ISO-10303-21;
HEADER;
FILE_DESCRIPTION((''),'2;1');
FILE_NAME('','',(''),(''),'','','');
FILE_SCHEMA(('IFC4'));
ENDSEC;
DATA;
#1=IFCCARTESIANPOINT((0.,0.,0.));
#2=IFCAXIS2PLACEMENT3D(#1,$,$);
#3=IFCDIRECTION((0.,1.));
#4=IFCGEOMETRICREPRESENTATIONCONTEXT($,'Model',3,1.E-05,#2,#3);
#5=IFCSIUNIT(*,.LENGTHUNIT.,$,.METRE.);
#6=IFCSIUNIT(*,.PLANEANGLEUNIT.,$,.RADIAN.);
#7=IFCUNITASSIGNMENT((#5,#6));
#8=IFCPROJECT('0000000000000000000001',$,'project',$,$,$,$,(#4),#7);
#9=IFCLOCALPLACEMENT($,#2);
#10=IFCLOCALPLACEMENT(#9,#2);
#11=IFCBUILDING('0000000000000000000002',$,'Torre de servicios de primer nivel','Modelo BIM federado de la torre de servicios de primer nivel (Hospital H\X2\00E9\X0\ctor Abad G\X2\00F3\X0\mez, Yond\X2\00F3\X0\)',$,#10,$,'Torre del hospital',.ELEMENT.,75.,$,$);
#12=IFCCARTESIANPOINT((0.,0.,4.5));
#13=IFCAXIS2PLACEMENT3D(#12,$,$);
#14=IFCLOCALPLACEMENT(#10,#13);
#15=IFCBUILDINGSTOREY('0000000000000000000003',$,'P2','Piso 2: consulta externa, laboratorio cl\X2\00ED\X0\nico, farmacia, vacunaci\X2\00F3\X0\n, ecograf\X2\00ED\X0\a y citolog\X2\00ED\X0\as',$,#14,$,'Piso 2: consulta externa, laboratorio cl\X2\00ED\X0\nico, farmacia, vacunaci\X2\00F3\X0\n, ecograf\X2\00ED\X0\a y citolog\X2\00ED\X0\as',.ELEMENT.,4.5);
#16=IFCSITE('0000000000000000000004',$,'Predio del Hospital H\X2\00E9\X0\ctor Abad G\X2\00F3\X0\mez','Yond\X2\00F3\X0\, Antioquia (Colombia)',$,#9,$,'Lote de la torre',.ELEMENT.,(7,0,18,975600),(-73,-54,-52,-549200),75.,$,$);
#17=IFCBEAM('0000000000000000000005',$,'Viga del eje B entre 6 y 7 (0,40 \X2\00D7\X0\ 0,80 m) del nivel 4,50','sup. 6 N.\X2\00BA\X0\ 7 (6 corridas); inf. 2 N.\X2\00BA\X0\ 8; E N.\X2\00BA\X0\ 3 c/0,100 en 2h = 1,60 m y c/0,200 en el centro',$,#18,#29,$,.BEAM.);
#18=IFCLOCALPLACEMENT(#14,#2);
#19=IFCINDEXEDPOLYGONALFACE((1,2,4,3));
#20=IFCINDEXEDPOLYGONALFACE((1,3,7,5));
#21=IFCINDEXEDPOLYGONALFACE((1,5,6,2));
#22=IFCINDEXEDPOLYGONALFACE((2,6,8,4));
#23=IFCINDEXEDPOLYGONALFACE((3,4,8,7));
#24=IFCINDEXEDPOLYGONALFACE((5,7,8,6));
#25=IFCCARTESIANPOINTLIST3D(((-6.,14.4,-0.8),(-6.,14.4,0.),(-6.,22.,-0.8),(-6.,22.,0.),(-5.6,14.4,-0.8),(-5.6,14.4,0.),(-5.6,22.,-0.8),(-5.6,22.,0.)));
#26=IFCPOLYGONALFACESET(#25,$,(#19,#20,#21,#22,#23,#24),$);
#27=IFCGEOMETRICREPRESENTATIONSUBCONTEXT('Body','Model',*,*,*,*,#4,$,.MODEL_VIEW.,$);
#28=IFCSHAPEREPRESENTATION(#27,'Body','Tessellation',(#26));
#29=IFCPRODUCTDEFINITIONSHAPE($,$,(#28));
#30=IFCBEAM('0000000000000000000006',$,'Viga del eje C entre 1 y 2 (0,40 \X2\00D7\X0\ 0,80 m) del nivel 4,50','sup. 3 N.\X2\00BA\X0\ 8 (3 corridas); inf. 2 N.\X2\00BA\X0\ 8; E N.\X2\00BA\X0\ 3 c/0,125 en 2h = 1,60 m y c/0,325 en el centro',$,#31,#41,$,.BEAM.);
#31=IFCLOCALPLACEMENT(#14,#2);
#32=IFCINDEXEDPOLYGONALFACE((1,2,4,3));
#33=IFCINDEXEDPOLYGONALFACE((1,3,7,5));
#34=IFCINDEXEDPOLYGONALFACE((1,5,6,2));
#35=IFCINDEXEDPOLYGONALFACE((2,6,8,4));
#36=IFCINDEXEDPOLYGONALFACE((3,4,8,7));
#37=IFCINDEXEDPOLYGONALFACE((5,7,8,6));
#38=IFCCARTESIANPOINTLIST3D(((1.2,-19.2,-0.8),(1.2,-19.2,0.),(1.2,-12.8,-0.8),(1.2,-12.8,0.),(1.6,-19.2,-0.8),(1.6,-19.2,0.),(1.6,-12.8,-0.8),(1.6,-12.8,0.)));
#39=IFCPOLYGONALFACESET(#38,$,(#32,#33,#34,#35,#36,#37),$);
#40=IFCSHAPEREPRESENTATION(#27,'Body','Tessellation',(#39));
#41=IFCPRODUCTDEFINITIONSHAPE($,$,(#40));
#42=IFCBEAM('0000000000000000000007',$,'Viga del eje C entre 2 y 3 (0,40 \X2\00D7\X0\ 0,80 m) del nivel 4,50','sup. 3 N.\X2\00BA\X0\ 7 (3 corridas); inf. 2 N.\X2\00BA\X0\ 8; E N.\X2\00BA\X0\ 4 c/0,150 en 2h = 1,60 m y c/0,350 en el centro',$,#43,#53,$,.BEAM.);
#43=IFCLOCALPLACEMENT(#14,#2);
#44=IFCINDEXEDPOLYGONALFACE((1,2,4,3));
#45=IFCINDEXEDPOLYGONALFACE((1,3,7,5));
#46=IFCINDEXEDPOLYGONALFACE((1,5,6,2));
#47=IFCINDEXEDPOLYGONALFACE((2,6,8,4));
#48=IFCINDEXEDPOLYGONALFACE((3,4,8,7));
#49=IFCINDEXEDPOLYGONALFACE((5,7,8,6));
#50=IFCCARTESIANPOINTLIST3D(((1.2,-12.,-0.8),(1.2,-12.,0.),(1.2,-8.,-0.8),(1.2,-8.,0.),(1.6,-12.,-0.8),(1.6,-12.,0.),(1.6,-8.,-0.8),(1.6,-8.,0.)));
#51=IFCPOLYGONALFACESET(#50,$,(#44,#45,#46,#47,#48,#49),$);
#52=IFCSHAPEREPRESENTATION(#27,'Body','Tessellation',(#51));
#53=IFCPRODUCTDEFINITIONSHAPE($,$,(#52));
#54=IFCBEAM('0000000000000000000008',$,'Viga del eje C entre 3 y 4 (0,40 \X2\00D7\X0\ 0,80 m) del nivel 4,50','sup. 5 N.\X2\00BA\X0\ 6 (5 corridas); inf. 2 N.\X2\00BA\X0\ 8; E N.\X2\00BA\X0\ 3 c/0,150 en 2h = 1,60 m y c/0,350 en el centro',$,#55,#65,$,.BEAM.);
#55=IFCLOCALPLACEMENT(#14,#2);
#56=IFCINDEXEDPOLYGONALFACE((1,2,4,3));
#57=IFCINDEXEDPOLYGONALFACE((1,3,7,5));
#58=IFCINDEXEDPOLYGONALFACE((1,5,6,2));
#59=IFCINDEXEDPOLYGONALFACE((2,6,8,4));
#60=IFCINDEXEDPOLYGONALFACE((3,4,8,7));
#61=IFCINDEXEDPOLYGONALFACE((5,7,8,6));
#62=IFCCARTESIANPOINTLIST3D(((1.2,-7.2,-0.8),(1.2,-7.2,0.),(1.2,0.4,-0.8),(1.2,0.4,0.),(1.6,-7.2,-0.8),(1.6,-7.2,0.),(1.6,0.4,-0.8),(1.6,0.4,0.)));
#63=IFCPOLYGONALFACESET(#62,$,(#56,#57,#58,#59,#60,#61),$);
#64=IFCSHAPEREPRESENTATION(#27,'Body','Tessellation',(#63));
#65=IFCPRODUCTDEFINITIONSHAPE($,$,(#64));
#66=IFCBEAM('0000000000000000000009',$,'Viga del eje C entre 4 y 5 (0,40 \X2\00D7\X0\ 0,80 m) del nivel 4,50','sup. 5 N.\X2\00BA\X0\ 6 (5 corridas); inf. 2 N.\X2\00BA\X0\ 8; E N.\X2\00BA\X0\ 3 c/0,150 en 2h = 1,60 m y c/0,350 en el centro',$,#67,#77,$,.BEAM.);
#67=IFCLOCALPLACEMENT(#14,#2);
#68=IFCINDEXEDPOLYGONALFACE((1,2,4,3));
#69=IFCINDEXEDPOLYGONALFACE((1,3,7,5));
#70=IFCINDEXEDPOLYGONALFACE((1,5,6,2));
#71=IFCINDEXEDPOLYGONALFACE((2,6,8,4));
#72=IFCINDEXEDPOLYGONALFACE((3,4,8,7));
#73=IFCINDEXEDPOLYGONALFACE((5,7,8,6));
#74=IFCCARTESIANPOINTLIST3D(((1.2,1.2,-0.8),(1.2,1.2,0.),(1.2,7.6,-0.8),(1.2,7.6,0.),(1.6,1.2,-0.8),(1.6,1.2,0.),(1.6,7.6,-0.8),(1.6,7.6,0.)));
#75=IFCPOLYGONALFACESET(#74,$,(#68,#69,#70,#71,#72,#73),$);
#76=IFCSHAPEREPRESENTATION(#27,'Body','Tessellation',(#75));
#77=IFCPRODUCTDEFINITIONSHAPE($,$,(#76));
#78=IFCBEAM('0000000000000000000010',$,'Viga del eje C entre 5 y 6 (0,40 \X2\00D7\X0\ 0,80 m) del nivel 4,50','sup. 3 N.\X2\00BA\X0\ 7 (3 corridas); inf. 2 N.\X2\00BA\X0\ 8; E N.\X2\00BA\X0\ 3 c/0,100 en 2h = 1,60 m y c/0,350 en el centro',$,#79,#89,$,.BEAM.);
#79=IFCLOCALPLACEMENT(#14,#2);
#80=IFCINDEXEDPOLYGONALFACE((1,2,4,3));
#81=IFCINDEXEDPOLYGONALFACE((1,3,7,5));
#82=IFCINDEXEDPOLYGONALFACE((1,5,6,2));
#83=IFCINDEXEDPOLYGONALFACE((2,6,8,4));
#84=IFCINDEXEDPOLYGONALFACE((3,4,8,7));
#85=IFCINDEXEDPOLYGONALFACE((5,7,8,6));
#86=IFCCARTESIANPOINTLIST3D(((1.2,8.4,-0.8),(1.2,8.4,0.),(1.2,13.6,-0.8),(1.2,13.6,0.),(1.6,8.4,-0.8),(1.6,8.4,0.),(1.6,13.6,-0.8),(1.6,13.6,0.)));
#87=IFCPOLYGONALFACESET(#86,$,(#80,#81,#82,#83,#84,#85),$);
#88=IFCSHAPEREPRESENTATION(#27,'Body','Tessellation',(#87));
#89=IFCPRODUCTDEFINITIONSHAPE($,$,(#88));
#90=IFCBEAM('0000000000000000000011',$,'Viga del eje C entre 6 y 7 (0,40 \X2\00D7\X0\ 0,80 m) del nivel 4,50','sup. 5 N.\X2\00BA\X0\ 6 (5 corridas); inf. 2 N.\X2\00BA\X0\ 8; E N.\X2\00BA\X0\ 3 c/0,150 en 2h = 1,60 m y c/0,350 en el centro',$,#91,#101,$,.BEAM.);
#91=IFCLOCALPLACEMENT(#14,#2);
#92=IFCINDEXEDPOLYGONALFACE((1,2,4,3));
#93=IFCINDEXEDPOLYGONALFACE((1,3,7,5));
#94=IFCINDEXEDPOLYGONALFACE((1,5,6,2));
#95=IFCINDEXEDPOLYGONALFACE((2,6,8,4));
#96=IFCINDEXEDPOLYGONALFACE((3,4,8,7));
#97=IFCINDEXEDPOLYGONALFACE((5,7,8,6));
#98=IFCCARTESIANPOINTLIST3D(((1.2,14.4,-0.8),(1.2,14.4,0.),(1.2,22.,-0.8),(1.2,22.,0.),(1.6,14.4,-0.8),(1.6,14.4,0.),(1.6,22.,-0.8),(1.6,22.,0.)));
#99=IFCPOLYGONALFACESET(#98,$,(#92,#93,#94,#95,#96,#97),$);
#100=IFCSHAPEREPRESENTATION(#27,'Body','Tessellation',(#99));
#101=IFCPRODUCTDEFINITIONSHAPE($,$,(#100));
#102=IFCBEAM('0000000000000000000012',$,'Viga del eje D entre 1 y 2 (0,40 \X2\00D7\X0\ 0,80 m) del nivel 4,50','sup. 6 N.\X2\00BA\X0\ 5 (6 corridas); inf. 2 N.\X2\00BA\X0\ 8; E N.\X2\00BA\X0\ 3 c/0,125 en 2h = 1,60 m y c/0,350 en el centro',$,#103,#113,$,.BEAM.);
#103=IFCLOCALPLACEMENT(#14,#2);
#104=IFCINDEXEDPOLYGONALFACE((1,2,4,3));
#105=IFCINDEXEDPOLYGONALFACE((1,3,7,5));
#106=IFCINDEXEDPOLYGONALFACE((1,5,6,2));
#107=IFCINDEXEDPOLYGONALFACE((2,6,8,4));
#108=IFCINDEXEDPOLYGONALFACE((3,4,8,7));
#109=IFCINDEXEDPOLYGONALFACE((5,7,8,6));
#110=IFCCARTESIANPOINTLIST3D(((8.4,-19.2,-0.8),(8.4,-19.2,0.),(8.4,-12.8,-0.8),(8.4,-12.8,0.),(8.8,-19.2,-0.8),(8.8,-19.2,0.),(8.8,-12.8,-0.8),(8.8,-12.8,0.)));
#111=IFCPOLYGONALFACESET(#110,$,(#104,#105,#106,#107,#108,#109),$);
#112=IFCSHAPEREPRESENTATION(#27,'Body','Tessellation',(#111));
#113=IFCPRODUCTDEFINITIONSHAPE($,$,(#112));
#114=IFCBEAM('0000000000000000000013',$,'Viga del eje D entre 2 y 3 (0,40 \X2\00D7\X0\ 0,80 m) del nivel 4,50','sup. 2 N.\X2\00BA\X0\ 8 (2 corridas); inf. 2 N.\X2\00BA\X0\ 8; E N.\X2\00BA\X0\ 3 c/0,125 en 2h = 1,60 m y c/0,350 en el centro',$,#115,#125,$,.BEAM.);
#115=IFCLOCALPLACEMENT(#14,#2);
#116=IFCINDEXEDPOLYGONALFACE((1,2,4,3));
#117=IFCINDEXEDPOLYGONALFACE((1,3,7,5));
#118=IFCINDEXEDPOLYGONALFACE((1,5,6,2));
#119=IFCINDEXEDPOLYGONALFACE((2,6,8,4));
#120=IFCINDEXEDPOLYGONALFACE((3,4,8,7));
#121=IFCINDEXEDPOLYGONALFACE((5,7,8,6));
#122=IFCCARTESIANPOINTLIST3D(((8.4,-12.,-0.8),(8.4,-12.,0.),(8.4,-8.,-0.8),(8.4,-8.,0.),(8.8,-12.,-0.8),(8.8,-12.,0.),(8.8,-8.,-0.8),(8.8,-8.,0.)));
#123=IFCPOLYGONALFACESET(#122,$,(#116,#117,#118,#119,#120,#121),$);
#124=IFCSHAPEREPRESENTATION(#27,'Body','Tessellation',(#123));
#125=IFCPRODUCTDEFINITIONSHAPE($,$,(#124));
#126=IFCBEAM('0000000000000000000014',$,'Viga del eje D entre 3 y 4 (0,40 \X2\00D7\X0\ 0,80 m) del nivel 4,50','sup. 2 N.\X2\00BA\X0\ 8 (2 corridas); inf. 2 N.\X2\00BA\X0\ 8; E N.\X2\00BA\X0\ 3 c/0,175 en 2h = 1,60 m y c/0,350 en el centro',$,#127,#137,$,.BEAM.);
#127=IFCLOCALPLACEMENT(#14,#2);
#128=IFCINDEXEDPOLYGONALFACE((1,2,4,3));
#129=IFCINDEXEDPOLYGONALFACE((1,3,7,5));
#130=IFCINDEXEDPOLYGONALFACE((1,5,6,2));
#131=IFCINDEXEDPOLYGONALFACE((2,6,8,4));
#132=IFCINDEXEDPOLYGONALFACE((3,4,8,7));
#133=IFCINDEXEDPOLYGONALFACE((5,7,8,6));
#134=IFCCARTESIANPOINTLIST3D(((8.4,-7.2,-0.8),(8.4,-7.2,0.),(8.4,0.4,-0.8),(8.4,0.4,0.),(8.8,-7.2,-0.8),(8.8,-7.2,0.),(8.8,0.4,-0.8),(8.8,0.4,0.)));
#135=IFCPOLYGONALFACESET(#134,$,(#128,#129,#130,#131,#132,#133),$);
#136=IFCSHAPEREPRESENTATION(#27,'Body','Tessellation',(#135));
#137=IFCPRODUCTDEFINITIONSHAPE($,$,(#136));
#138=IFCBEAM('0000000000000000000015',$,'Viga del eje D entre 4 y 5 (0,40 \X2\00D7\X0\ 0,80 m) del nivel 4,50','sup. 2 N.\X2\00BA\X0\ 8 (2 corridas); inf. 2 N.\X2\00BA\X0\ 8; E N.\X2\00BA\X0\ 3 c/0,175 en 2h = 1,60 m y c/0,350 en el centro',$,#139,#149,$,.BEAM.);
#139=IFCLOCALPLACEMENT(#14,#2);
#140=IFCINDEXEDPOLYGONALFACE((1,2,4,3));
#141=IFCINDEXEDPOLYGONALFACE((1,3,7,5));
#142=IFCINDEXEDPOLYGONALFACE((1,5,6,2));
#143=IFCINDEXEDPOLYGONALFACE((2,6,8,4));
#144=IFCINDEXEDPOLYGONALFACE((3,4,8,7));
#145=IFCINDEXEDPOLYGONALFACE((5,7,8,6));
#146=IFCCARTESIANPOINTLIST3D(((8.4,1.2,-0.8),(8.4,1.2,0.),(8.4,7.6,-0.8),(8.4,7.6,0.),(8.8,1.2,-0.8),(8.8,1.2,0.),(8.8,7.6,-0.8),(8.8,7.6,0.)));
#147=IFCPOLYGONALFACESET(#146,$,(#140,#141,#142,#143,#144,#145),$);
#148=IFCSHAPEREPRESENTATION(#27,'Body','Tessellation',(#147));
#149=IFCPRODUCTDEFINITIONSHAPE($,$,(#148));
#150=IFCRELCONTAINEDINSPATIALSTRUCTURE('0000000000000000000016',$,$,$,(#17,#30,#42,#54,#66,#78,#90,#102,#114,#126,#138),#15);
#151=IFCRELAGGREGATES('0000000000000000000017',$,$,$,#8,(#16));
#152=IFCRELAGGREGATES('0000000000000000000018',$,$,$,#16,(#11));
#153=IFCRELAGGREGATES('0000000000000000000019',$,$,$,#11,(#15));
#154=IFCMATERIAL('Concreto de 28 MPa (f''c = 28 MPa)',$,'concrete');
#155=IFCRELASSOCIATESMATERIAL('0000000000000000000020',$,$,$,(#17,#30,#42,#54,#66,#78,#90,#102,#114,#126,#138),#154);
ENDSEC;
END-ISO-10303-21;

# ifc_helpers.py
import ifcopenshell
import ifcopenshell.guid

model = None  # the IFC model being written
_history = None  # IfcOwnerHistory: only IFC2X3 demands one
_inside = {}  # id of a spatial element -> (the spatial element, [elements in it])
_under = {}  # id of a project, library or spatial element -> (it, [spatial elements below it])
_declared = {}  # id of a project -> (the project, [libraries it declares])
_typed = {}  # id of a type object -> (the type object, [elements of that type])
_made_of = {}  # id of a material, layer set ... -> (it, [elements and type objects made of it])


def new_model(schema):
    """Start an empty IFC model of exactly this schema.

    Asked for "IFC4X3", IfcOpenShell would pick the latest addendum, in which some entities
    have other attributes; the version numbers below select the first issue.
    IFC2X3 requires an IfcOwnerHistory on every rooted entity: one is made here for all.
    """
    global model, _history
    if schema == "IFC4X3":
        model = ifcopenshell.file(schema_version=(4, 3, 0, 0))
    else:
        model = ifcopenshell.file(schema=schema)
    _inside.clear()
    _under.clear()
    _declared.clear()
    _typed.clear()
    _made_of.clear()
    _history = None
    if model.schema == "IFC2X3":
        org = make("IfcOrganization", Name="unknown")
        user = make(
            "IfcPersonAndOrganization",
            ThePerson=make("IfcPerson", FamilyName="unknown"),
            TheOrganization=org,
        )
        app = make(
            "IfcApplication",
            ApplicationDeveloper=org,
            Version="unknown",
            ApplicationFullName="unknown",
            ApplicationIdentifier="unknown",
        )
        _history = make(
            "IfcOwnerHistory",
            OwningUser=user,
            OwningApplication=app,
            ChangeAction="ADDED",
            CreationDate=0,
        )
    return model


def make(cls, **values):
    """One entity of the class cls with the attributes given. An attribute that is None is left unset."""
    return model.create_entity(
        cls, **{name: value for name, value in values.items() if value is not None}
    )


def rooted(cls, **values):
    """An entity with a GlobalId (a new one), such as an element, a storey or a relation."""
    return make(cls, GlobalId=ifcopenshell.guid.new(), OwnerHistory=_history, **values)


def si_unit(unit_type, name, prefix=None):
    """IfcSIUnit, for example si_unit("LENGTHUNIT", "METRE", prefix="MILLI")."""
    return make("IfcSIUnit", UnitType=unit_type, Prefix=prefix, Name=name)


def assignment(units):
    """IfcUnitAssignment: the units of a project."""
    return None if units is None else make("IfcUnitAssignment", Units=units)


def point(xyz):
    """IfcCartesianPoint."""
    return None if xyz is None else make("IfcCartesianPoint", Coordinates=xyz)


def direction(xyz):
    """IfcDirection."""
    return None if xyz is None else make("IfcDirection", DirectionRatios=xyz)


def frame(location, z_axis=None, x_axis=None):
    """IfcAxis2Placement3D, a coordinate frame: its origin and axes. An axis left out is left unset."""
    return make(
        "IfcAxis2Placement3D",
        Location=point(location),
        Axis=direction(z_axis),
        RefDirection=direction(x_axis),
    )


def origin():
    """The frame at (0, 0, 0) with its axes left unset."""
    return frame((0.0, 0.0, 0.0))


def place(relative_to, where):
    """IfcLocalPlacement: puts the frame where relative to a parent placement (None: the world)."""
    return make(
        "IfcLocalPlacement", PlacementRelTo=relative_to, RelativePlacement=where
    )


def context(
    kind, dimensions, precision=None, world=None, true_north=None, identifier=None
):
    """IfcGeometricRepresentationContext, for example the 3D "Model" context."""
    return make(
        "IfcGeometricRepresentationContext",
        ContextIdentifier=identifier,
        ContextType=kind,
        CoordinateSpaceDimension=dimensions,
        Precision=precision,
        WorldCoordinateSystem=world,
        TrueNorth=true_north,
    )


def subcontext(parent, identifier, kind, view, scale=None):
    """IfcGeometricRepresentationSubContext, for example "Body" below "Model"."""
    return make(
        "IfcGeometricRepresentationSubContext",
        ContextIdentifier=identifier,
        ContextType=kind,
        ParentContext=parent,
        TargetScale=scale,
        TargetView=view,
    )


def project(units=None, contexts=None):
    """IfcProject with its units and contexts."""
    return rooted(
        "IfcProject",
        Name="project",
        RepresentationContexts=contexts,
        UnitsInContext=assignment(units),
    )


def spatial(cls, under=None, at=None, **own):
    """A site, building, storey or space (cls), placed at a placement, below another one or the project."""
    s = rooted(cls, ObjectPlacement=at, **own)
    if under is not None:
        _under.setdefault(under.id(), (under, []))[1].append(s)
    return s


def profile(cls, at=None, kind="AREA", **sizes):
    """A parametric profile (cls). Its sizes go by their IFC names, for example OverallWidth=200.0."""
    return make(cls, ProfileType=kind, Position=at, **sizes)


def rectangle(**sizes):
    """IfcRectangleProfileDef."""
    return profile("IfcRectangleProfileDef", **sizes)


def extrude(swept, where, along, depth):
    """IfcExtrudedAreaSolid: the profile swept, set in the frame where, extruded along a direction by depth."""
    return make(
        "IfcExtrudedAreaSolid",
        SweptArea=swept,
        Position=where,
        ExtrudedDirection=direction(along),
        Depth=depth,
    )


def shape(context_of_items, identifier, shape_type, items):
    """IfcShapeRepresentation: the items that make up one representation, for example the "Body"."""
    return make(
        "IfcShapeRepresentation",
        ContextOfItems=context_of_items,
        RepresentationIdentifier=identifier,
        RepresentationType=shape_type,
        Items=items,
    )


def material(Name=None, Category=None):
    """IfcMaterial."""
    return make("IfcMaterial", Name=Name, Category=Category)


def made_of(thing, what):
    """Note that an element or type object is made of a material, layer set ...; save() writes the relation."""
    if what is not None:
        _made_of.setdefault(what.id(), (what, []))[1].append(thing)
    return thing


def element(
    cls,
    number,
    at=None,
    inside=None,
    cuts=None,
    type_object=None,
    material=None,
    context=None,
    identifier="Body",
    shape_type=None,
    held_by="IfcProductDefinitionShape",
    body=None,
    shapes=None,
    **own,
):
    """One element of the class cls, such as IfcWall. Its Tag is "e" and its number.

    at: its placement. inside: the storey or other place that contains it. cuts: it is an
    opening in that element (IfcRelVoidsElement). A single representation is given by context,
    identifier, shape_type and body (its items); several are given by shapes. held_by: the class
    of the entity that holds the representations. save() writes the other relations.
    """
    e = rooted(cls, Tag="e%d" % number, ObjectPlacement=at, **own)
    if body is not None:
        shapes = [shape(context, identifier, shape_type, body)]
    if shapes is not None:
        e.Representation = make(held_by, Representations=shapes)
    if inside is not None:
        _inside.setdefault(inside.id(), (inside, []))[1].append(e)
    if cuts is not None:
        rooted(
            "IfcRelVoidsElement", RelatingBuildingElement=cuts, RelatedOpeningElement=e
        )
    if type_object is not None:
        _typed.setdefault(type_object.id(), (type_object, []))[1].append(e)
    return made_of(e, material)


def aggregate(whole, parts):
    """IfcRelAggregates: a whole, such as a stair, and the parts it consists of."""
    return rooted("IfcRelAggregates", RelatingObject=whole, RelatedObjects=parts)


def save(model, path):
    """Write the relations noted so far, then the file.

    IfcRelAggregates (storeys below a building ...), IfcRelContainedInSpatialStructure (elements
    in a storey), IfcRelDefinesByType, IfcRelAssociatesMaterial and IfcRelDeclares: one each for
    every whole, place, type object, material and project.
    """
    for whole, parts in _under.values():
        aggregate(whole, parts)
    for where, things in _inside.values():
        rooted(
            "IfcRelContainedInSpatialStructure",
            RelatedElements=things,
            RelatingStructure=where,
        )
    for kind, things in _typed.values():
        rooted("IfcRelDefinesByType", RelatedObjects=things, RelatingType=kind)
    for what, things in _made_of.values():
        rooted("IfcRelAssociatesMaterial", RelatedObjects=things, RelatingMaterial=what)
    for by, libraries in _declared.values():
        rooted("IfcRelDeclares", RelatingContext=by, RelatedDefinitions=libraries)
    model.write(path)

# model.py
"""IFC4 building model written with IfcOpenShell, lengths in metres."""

from ifc_helpers import new_model, si_unit, direction, frame, origin, place, context, subcontext, project, spatial, rectangle, extrude, material, element, save


model = new_model("IFC4")

# Units and contexts
model_context = context("Model", 3, precision=1e-05, world=origin(), true_north=direction((0.0, 1.0)))
body_context = subcontext(model_context, "Body", "Model", "MODEL_VIEW")
ifc_project = project(units=[si_unit("LENGTHUNIT", "METRE"), si_unit("PLANEANGLEUNIT", "RADIAN")], contexts=[model_context])

# Site, building, storey
site_placement = place(None, origin())
site = spatial("IfcSite", under=ifc_project, at=site_placement, Name="Predio del Hospital Héctor Abad Gómez", Description="Yondó, Antioquia (Colombia)", LongName="Lote de la torre", CompositionType="ELEMENT", RefLatitude=(7, 0, 18, 975600), RefLongitude=(-73, -54, -52, -549200), RefElevation=75.0)
building_placement = place(site_placement, origin())
building = spatial("IfcBuilding", under=site, at=building_placement, Name="Torre de servicios de primer nivel", Description="Modelo BIM federado de la torre de servicios de primer nivel (Hospital Héctor Abad Gómez, Yondó)", LongName="Torre del hospital", CompositionType="ELEMENT", ElevationOfRefHeight=75.0)
placement = place(building_placement, frame((0.0, 0.0, 4.5)))
storey = spatial("IfcBuildingStorey", under=building, at=placement, Name="P2", Description="Piso 2: consulta externa, laboratorio clínico, farmacia, vacunación, ecografía y citologías", LongName="Piso 2: consulta externa, laboratorio clínico, farmacia, vacunación, ecografía y citologías", CompositionType="ELEMENT", Elevation=4.5)

# Beams
ifc_material = material(Name="Concreto de 28 MPa (f'c = 28 MPa)", Category="concrete")
element("IfcBeam", 1, at=placement, inside=storey, material=ifc_material, Name="Viga del eje B entre 6 y 7 (0,40 × 0,80 m) del nivel 4,50", Description="sup. 6 N.º 7 (6 corridas); inf. 2 N.º 8; E N.º 3 c/0,100 en 2h = 1,60 m y c/0,200 en el centro", PredefinedType="BEAM", context=body_context, shape_type="SweptSolid", body=[
    extrude(rectangle(XDim=0.4, YDim=7.6), frame((-5.8, 18.2, -0.8)), (0.0, 0.0, 1.0), 0.8),
])
element("IfcBeam", 2, at=placement, inside=storey, material=ifc_material, Name="Viga del eje C entre 1 y 2 (0,40 × 0,80 m) del nivel 4,50", Description="sup. 3 N.º 8 (3 corridas); inf. 2 N.º 8; E N.º 3 c/0,125 en 2h = 1,60 m y c/0,325 en el centro", PredefinedType="BEAM", context=body_context, shape_type="SweptSolid", body=[
    extrude(rectangle(XDim=0.4, YDim=6.4), frame((1.4, -16.0, -0.8)), (0.0, 0.0, 1.0), 0.8),
])
element("IfcBeam", 3, at=placement, inside=storey, material=ifc_material, Name="Viga del eje C entre 2 y 3 (0,40 × 0,80 m) del nivel 4,50", Description="sup. 3 N.º 7 (3 corridas); inf. 2 N.º 8; E N.º 4 c/0,150 en 2h = 1,60 m y c/0,350 en el centro", PredefinedType="BEAM", context=body_context, shape_type="SweptSolid", body=[
    extrude(rectangle(XDim=0.4, YDim=4.0), frame((1.4, -10.0, -0.8)), (0.0, 0.0, 1.0), 0.8),
])
element("IfcBeam", 4, at=placement, inside=storey, material=ifc_material, Name="Viga del eje C entre 3 y 4 (0,40 × 0,80 m) del nivel 4,50", Description="sup. 5 N.º 6 (5 corridas); inf. 2 N.º 8; E N.º 3 c/0,150 en 2h = 1,60 m y c/0,350 en el centro", PredefinedType="BEAM", context=body_context, shape_type="SweptSolid", body=[
    extrude(rectangle(XDim=0.4, YDim=7.6), frame((1.4, -3.4, -0.8)), (0.0, 0.0, 1.0), 0.8),
])
element("IfcBeam", 5, at=placement, inside=storey, material=ifc_material, Name="Viga del eje C entre 4 y 5 (0,40 × 0,80 m) del nivel 4,50", Description="sup. 5 N.º 6 (5 corridas); inf. 2 N.º 8; E N.º 3 c/0,150 en 2h = 1,60 m y c/0,350 en el centro", PredefinedType="BEAM", context=body_context, shape_type="SweptSolid", body=[
    extrude(rectangle(XDim=0.4, YDim=6.4), frame((1.4, 4.4, -0.8)), (0.0, 0.0, 1.0), 0.8),
])
element("IfcBeam", 6, at=placement, inside=storey, material=ifc_material, Name="Viga del eje C entre 5 y 6 (0,40 × 0,80 m) del nivel 4,50", Description="sup. 3 N.º 7 (3 corridas); inf. 2 N.º 8; E N.º 3 c/0,100 en 2h = 1,60 m y c/0,350 en el centro", PredefinedType="BEAM", context=body_context, shape_type="SweptSolid", body=[
    extrude(rectangle(XDim=0.4, YDim=5.2), frame((1.4, 11.0, -0.8)), (0.0, 0.0, 1.0), 0.8),
])
element("IfcBeam", 7, at=placement, inside=storey, material=ifc_material, Name="Viga del eje C entre 6 y 7 (0,40 × 0,80 m) del nivel 4,50", Description="sup. 5 N.º 6 (5 corridas); inf. 2 N.º 8; E N.º 3 c/0,150 en 2h = 1,60 m y c/0,350 en el centro", PredefinedType="BEAM", context=body_context, shape_type="SweptSolid", body=[
    extrude(rectangle(XDim=0.4, YDim=7.6), frame((1.4, 18.2, -0.8)), (0.0, 0.0, 1.0), 0.8),
])
element("IfcBeam", 8, at=placement, inside=storey, material=ifc_material, Name="Viga del eje D entre 1 y 2 (0,40 × 0,80 m) del nivel 4,50", Description="sup. 6 N.º 5 (6 corridas); inf. 2 N.º 8; E N.º 3 c/0,125 en 2h = 1,60 m y c/0,350 en el centro", PredefinedType="BEAM", context=body_context, shape_type="SweptSolid", body=[
    extrude(rectangle(XDim=0.4, YDim=6.4), frame((8.6, -16.0, -0.8)), (0.0, 0.0, 1.0), 0.8),
])
element("IfcBeam", 9, at=placement, inside=storey, material=ifc_material, Name="Viga del eje D entre 2 y 3 (0,40 × 0,80 m) del nivel 4,50", Description="sup. 2 N.º 8 (2 corridas); inf. 2 N.º 8; E N.º 3 c/0,125 en 2h = 1,60 m y c/0,350 en el centro", PredefinedType="BEAM", context=body_context, shape_type="SweptSolid", body=[
    extrude(rectangle(XDim=0.4, YDim=4.0), frame((8.6, -10.0, -0.8)), (0.0, 0.0, 1.0), 0.8),
])
element("IfcBeam", 10, at=placement, inside=storey, material=ifc_material, Name="Viga del eje D entre 3 y 4 (0,40 × 0,80 m) del nivel 4,50", Description="sup. 2 N.º 8 (2 corridas); inf. 2 N.º 8; E N.º 3 c/0,175 en 2h = 1,60 m y c/0,350 en el centro", PredefinedType="BEAM", context=body_context, shape_type="SweptSolid", body=[
    extrude(rectangle(XDim=0.4, YDim=7.6), frame((8.6, -3.4, -0.8)), (0.0, 0.0, 1.0), 0.8),
])
element("IfcBeam", 11, at=placement, inside=storey, material=ifc_material, Name="Viga del eje D entre 4 y 5 (0,40 × 0,80 m) del nivel 4,50", Description="sup. 2 N.º 8 (2 corridas); inf. 2 N.º 8; E N.º 3 c/0,175 en 2h = 1,60 m y c/0,350 en el centro", PredefinedType="BEAM", context=body_context, shape_type="SweptSolid", body=[
    extrude(rectangle(XDim=0.4, YDim=6.4), frame((8.6, 4.4, -0.8)), (0.0, 0.0, 1.0), 0.8),
])

save(model, "model.ifc")
